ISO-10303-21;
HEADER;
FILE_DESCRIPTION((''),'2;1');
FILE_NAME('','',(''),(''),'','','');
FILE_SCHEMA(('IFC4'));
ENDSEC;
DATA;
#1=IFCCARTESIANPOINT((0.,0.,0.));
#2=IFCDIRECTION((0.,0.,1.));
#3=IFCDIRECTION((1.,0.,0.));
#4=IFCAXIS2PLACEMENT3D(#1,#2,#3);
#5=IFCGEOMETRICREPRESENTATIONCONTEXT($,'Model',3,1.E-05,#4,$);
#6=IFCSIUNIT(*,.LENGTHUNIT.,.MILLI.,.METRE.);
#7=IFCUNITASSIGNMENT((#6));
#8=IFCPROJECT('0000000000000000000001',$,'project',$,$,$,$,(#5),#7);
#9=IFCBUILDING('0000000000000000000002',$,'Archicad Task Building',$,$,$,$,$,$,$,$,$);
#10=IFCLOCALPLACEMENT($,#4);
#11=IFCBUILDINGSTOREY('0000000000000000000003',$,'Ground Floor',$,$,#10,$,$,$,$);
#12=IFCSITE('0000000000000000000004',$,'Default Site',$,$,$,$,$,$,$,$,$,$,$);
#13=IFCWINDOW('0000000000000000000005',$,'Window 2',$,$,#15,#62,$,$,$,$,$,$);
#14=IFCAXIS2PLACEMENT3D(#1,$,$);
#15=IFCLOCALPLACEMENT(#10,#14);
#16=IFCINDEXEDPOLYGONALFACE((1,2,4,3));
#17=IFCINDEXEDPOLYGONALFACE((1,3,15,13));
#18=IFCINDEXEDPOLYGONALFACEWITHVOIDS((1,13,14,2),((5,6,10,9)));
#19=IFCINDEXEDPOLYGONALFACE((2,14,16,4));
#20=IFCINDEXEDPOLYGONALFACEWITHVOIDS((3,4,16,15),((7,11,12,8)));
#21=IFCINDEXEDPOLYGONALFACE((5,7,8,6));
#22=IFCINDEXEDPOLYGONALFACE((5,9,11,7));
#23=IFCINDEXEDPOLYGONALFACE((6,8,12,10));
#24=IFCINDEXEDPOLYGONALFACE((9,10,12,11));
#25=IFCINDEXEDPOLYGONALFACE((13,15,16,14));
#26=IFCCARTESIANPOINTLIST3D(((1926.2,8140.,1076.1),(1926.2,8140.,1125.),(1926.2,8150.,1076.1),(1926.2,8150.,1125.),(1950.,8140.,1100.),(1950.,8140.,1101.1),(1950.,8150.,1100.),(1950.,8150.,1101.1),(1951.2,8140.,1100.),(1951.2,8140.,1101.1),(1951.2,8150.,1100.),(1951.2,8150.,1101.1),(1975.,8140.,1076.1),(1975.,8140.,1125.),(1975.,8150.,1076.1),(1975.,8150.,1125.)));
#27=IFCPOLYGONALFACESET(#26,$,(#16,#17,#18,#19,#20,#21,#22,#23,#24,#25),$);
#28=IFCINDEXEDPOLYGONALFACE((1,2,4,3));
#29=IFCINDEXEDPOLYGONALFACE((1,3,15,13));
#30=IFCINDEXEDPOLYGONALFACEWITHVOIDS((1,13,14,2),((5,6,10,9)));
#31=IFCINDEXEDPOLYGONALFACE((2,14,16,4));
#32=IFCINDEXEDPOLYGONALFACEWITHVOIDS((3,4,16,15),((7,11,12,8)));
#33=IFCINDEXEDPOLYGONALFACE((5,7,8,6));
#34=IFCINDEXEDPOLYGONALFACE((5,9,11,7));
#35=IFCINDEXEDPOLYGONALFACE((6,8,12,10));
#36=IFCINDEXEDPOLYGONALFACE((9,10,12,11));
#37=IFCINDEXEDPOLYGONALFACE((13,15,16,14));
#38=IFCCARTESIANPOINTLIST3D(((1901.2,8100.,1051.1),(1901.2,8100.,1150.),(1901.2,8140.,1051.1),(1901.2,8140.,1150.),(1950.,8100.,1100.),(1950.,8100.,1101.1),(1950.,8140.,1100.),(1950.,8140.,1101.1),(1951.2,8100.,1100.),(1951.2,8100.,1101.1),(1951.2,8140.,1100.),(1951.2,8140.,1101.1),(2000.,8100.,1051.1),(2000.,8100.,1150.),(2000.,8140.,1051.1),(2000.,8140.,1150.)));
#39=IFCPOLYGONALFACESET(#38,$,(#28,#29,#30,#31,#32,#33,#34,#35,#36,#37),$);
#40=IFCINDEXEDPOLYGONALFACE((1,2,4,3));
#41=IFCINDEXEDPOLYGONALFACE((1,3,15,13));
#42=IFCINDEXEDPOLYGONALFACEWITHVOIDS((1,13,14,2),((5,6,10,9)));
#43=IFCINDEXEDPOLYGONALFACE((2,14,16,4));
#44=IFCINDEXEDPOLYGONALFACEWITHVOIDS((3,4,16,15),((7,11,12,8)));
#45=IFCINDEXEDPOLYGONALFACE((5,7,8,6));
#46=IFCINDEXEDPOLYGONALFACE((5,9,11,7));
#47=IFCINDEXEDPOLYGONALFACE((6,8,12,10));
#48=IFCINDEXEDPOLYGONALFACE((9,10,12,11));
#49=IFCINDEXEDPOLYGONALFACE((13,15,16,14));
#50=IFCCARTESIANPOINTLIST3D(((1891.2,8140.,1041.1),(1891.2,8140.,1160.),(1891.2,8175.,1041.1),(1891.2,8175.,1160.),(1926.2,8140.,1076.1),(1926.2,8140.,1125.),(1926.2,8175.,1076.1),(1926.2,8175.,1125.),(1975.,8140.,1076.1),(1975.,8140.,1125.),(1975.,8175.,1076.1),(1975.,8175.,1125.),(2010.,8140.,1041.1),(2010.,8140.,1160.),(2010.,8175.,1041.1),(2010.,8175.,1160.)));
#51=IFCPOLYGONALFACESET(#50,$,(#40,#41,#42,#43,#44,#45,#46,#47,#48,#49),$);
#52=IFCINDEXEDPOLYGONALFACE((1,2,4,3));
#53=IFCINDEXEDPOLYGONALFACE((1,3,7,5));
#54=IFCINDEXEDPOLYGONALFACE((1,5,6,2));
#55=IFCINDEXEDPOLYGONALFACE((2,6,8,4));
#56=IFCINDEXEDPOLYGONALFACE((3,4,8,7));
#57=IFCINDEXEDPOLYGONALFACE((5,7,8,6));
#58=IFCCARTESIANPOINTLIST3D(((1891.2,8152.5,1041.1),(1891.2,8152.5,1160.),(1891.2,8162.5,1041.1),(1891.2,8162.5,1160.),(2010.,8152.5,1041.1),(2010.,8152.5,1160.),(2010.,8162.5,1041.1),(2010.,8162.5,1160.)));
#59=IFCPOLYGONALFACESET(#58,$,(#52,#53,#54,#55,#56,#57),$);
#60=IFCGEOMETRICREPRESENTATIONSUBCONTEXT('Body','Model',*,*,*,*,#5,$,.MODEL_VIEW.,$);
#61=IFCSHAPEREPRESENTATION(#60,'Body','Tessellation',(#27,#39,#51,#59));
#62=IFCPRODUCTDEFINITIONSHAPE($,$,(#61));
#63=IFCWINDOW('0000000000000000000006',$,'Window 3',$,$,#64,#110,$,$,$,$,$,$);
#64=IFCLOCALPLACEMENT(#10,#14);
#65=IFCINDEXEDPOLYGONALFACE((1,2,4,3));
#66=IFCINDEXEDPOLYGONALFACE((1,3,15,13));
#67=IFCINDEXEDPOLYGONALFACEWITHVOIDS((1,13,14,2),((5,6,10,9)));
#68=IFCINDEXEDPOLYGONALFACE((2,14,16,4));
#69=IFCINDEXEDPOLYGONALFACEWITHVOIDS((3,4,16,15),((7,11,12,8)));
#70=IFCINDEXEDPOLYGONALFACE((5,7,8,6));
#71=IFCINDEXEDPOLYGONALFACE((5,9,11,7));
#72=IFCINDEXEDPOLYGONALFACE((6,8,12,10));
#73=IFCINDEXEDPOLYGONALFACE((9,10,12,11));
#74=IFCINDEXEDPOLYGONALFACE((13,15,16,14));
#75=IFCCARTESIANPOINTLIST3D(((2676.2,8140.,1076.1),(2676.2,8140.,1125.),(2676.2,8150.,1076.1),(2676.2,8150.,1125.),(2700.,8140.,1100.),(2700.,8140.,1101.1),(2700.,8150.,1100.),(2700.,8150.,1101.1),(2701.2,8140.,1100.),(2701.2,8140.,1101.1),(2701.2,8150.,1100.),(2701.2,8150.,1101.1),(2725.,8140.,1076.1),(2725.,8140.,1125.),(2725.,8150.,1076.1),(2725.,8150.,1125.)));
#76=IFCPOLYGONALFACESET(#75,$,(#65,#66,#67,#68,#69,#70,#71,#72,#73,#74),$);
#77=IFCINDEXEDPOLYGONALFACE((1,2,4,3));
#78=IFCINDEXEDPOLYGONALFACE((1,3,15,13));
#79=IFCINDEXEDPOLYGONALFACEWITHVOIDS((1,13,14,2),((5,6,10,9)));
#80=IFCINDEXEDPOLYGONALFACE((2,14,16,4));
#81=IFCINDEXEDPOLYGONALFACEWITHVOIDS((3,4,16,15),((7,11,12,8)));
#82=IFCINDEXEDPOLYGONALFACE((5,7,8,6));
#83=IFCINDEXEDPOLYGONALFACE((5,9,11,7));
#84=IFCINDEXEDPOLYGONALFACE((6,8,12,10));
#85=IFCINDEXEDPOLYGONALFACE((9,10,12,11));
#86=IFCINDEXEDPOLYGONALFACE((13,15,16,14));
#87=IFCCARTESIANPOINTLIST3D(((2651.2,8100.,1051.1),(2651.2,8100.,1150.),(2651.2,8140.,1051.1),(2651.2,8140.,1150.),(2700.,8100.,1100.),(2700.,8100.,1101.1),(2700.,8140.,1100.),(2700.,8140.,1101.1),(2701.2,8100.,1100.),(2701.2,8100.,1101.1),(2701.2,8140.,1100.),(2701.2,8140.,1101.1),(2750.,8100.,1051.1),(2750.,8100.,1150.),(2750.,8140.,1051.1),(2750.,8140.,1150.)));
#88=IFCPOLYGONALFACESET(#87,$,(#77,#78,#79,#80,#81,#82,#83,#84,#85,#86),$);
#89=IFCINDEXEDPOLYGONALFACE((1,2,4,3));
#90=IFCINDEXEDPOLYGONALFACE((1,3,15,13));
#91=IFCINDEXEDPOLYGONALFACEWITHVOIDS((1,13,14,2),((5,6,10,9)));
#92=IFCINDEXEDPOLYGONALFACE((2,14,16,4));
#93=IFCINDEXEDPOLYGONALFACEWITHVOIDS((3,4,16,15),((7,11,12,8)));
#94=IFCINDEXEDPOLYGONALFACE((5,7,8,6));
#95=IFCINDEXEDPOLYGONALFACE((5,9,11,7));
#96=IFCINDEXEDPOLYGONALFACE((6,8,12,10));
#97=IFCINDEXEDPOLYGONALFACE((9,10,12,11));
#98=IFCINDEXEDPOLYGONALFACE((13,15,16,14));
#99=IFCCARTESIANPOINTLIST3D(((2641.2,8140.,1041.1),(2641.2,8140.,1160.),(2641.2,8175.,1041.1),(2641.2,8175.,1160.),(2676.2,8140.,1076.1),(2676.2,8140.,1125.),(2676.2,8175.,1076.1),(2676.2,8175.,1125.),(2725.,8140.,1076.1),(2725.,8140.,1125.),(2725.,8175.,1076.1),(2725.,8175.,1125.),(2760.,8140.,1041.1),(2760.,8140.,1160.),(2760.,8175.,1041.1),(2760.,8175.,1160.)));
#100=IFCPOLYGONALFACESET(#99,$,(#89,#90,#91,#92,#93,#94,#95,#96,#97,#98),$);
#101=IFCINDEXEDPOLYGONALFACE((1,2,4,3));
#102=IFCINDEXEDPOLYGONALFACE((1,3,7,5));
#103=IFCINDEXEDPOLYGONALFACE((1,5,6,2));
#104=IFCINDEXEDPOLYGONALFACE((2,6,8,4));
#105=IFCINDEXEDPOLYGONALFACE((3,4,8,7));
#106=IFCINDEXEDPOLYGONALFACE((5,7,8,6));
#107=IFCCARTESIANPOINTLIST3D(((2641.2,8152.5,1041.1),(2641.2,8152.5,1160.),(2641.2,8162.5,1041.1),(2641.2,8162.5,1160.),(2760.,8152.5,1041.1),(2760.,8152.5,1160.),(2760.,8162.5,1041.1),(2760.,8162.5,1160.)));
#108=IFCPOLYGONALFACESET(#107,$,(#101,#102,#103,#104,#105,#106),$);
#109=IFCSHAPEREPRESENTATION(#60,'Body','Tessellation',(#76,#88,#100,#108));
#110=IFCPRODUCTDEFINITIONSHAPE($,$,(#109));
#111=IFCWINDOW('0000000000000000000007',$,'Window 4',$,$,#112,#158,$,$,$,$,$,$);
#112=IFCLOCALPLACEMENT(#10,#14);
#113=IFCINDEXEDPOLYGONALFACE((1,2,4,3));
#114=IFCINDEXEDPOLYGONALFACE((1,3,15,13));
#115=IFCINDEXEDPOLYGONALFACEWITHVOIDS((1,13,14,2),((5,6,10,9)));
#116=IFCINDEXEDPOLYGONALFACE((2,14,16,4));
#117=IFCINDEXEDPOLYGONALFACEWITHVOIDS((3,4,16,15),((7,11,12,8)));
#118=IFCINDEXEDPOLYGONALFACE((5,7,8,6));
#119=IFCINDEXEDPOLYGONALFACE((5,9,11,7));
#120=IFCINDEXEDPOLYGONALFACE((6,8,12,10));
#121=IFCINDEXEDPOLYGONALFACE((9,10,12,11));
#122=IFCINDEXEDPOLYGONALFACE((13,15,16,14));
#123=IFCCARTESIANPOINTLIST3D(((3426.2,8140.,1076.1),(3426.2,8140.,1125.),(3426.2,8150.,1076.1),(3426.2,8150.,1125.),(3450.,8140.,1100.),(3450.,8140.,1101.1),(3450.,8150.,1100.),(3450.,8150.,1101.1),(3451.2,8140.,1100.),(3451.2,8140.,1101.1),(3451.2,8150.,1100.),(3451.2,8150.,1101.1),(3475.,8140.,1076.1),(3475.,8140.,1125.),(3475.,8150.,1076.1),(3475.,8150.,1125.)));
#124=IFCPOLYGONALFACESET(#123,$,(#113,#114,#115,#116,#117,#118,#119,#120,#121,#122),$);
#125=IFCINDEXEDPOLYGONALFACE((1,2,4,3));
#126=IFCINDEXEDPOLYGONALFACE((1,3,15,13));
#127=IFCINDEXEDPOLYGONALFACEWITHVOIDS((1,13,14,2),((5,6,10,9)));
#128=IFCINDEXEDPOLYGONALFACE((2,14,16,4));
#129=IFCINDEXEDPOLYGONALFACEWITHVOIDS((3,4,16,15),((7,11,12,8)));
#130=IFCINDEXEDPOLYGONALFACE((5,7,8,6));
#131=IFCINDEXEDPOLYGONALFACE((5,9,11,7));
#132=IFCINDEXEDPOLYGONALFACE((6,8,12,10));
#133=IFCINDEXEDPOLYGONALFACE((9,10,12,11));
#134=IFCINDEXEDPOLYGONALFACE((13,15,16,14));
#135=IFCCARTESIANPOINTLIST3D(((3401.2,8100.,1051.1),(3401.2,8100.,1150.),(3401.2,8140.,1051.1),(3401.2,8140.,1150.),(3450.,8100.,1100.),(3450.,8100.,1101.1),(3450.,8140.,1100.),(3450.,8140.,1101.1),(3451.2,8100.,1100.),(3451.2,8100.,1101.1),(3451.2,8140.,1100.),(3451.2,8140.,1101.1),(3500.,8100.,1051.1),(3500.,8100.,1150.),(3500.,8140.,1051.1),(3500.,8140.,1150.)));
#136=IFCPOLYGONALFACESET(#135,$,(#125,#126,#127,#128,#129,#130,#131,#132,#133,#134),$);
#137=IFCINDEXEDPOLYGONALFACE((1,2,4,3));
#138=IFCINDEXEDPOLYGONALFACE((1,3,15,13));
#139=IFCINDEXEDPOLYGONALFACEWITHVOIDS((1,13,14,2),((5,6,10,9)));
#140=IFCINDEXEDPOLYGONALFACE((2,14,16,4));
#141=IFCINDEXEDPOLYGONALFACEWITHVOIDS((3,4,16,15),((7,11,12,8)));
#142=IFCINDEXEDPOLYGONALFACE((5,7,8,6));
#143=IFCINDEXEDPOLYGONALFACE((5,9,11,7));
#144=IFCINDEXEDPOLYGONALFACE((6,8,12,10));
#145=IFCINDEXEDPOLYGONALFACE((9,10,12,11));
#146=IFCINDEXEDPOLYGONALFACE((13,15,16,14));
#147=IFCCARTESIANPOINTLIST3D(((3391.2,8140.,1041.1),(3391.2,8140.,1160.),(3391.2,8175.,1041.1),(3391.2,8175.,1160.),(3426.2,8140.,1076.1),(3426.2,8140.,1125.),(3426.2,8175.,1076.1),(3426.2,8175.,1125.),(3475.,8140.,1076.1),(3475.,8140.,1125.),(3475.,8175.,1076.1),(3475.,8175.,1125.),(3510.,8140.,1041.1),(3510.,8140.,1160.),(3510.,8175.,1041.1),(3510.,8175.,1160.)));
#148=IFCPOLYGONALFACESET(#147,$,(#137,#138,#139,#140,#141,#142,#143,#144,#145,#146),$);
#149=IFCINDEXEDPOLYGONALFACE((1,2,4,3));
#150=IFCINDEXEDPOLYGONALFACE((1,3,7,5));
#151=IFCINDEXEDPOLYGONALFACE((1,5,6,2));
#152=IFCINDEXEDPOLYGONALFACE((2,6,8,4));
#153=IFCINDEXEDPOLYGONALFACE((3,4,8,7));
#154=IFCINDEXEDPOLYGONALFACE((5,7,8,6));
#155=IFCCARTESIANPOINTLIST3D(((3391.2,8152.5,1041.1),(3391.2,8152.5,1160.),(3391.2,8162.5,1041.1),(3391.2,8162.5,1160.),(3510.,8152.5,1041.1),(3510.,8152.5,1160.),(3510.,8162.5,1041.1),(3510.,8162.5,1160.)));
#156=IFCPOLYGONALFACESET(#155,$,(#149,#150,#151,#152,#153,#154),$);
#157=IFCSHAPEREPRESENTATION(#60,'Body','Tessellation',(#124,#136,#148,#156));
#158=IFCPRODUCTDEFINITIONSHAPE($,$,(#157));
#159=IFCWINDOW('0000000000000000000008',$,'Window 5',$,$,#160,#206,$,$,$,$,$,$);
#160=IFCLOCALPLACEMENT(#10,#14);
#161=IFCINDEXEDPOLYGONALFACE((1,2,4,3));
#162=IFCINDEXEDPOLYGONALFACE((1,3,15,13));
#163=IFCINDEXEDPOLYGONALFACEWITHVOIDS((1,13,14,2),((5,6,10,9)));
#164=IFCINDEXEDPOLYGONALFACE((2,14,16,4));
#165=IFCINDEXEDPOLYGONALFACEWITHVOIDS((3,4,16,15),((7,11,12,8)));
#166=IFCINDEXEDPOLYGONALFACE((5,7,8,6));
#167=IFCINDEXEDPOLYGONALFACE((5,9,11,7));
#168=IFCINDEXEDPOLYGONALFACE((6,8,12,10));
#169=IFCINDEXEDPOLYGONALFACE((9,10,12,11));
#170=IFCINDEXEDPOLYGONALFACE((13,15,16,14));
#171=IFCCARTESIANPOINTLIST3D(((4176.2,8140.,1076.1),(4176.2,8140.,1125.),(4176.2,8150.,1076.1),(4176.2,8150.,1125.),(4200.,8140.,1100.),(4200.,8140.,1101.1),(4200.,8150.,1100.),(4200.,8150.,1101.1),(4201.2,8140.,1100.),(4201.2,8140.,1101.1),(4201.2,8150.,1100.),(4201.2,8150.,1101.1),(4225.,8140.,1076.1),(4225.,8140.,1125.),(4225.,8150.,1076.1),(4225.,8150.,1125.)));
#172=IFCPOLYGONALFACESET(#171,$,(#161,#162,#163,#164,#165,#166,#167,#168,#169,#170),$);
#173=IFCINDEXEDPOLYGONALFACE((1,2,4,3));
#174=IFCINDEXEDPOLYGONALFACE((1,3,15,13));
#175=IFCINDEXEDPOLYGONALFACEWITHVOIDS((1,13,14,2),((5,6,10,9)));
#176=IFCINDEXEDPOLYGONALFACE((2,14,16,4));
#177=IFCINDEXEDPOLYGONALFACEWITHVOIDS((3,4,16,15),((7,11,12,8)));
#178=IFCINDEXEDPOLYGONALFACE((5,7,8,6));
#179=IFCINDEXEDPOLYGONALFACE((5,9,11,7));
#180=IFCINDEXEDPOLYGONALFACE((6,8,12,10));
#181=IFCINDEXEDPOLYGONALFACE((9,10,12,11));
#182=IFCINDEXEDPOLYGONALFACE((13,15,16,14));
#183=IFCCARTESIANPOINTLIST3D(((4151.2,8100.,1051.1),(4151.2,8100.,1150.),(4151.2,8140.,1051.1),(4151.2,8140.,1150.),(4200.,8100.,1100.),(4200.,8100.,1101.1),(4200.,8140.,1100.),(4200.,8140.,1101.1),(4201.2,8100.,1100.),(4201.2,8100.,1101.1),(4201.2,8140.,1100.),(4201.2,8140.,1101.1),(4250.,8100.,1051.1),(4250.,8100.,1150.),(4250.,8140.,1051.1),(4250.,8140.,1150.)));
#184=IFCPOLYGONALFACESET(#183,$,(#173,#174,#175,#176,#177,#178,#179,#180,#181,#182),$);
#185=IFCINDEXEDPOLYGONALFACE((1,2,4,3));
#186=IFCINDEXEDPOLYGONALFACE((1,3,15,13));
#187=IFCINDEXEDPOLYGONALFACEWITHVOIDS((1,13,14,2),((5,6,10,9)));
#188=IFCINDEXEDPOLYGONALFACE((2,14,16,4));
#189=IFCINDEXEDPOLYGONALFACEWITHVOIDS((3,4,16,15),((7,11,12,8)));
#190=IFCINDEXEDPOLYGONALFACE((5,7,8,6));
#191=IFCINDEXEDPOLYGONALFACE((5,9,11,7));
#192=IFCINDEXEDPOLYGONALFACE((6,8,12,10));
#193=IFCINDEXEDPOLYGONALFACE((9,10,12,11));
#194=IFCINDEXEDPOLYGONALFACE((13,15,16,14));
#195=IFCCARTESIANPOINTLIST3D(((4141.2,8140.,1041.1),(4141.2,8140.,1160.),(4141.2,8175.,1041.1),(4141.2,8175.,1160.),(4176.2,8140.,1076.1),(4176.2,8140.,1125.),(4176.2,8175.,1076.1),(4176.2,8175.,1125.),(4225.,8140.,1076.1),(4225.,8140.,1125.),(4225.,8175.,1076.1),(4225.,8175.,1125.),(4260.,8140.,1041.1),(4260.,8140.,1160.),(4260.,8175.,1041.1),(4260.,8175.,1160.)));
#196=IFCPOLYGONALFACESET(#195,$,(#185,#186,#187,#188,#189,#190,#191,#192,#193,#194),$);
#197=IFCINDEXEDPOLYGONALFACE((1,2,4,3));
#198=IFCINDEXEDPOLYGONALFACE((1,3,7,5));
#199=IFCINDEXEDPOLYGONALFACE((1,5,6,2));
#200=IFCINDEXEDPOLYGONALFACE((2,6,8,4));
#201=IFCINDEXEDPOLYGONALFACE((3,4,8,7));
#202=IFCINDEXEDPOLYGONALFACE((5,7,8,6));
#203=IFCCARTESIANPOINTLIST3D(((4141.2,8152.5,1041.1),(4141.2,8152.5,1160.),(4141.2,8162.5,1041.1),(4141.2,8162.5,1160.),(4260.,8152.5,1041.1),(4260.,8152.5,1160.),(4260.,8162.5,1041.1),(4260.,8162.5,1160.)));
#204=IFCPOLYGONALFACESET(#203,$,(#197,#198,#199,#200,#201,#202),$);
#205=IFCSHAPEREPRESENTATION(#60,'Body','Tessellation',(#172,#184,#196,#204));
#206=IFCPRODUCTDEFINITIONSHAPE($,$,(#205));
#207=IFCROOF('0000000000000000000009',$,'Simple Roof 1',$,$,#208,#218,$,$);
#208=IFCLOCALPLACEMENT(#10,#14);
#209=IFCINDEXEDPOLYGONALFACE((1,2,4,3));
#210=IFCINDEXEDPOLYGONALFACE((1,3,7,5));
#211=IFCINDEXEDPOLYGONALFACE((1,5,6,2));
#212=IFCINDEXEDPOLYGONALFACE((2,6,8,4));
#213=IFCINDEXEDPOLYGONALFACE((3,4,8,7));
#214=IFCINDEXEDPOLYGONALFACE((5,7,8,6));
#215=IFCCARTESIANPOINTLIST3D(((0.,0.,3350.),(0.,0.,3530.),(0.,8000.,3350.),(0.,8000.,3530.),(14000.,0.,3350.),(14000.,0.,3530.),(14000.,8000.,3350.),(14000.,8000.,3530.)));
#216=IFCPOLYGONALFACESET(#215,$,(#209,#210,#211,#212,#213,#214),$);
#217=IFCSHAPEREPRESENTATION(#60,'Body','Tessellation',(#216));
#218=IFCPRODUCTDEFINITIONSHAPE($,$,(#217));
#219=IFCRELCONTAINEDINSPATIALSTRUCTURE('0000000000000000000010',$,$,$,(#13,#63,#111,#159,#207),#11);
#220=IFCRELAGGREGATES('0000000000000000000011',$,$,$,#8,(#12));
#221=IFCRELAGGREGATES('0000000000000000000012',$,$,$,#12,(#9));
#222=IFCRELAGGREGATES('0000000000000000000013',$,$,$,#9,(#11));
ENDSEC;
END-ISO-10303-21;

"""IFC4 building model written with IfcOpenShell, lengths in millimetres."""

from ifc_helpers import new_model, si_unit, frame, origin_with_axes, place, context, subcontext, project, spatial, line, indexed_curve, outline, extrude, element, save


model = new_model("IFC4")

# Units and contexts
model_context = context("Model", 3, precision=1e-05, world=origin_with_axes())
body_context = subcontext(model_context, "Body", "Model", "MODEL_VIEW")
ifc_project = project(units=[si_unit("LENGTHUNIT", "METRE", prefix="MILLI")], contexts=[model_context])

# Site, building, storey
site = spatial("IfcSite", under=ifc_project, Name="Default Site")
building = spatial("IfcBuilding", under=site, Name="Archicad Task Building")
storey_placement = place(None, origin_with_axes())
storey = spatial("IfcBuildingStorey", under=building, at=storey_placement, Name="Ground Floor")

# Windows
for number, where, z_axis, x_axis, name in (
    (1, (1950.0, 8050.0, 1100.0), (0.0, 0.0, 1.0), (1.0, 0.0, 0.0), "Window 2"),
    (2, (2700.0, 8050.0, 1100.0), (0.0, 0.0, 1.0), (1.0, 0.0, 0.0), "Window 3"),
    (3, (3450.0, 8050.0, 1100.0), (0.0, 0.0, 1.0), (1.0, 0.0, 0.0), "Window 4"),
    (4, (4200.0, 8050.0, 1100.0), (0.0, 0.0, 1.0), (1.0, 0.0, 0.0), "Window 5"),
):
    element("IfcWindow", number, at=place(storey_placement, frame(where, z_axis=z_axis, x_axis=x_axis)), inside=storey, Name=name, context=body_context, shape_type="SweptSolid", body=[
        extrude(outline(indexed_curve([(0.0, 0.0), (1.2, 0.0), (1.2, 1.1), (0.0, 1.1)], segments=[line(1, 2, 3, 4, 1)]), holes=[indexed_curve([(25.0, 25.0), (-23.8, 25.0), (-23.8, -23.9), (25.0, -23.9)], segments=[line(1, 2, 3, 4, 1)])]), frame((0.0, 90.0, 0.0), z_axis=(0.0, -1.0, 0.0), x_axis=(1.0, 0.0, 0.0)), (0.0, 0.0, -1.0), 10.0),
        extrude(outline(indexed_curve([(0.0, 0.0), (1.2, 0.0), (1.2, 1.1), (0.0, 1.1)], segments=[line(1, 2, 3, 4, 1)]), holes=[indexed_curve([(50.0, 50.0), (-48.8, 50.0), (-48.8, -48.9), (50.0, -48.9)], segments=[line(1, 2, 3, 4, 1)])]), frame((0.0, 50.0, 0.0), z_axis=(0.0, -1.0, 0.0), x_axis=(1.0, 0.0, 0.0)), (0.0, 0.0, -1.0), 40.0),
        extrude(outline(indexed_curve([(0.0, 0.0), (-48.8, 0.0), (-48.8, -48.9), (0.0, -48.9)], segments=[line(1, 2, 3, 4, 1)]), holes=[indexed_curve([(35.0, 35.0), (-83.8, 35.0), (-83.8, -83.9), (35.0, -83.9)], segments=[line(1, 2, 3, 4, 1)])]), frame((25.0, 90.0, 25.0), z_axis=(0.0, -1.0, 0.0), x_axis=(1.0, 0.0, 0.0)), (0.0, 0.0, -1.0), 35.0),
        extrude(outline(indexed_curve([(35.0, 35.0), (-83.8, 35.0), (-83.8, -83.9), (35.0, -83.9)], segments=[line(1, 2, 3, 4, 1)])), frame((25.0, 102.5, 25.0), z_axis=(0.0, -1.0, 0.0), x_axis=(1.0, 0.0, 0.0)), (0.0, 0.0, -1.0), 10.0),
    ])

# Roof
roof_placement = place(storey_placement, frame((0.0, 0.0, 3350.0), z_axis=(0.0, 0.0, 1.0), x_axis=(1.0, 0.0, 0.0)))
element("IfcRoof", 5, at=roof_placement, inside=storey, Name="Simple Roof 1", context=body_context, shape_type="SweptSolid", body=[
    extrude(outline(indexed_curve([(0.0, 0.0), (14000.0, 0.0), (14000.0, 8000.0), (0.0, 8000.0), (0.0, 0.0)])), None, (0.0, 0.0, 1.0), 180.0),
])

save(model, "model.ifc")
